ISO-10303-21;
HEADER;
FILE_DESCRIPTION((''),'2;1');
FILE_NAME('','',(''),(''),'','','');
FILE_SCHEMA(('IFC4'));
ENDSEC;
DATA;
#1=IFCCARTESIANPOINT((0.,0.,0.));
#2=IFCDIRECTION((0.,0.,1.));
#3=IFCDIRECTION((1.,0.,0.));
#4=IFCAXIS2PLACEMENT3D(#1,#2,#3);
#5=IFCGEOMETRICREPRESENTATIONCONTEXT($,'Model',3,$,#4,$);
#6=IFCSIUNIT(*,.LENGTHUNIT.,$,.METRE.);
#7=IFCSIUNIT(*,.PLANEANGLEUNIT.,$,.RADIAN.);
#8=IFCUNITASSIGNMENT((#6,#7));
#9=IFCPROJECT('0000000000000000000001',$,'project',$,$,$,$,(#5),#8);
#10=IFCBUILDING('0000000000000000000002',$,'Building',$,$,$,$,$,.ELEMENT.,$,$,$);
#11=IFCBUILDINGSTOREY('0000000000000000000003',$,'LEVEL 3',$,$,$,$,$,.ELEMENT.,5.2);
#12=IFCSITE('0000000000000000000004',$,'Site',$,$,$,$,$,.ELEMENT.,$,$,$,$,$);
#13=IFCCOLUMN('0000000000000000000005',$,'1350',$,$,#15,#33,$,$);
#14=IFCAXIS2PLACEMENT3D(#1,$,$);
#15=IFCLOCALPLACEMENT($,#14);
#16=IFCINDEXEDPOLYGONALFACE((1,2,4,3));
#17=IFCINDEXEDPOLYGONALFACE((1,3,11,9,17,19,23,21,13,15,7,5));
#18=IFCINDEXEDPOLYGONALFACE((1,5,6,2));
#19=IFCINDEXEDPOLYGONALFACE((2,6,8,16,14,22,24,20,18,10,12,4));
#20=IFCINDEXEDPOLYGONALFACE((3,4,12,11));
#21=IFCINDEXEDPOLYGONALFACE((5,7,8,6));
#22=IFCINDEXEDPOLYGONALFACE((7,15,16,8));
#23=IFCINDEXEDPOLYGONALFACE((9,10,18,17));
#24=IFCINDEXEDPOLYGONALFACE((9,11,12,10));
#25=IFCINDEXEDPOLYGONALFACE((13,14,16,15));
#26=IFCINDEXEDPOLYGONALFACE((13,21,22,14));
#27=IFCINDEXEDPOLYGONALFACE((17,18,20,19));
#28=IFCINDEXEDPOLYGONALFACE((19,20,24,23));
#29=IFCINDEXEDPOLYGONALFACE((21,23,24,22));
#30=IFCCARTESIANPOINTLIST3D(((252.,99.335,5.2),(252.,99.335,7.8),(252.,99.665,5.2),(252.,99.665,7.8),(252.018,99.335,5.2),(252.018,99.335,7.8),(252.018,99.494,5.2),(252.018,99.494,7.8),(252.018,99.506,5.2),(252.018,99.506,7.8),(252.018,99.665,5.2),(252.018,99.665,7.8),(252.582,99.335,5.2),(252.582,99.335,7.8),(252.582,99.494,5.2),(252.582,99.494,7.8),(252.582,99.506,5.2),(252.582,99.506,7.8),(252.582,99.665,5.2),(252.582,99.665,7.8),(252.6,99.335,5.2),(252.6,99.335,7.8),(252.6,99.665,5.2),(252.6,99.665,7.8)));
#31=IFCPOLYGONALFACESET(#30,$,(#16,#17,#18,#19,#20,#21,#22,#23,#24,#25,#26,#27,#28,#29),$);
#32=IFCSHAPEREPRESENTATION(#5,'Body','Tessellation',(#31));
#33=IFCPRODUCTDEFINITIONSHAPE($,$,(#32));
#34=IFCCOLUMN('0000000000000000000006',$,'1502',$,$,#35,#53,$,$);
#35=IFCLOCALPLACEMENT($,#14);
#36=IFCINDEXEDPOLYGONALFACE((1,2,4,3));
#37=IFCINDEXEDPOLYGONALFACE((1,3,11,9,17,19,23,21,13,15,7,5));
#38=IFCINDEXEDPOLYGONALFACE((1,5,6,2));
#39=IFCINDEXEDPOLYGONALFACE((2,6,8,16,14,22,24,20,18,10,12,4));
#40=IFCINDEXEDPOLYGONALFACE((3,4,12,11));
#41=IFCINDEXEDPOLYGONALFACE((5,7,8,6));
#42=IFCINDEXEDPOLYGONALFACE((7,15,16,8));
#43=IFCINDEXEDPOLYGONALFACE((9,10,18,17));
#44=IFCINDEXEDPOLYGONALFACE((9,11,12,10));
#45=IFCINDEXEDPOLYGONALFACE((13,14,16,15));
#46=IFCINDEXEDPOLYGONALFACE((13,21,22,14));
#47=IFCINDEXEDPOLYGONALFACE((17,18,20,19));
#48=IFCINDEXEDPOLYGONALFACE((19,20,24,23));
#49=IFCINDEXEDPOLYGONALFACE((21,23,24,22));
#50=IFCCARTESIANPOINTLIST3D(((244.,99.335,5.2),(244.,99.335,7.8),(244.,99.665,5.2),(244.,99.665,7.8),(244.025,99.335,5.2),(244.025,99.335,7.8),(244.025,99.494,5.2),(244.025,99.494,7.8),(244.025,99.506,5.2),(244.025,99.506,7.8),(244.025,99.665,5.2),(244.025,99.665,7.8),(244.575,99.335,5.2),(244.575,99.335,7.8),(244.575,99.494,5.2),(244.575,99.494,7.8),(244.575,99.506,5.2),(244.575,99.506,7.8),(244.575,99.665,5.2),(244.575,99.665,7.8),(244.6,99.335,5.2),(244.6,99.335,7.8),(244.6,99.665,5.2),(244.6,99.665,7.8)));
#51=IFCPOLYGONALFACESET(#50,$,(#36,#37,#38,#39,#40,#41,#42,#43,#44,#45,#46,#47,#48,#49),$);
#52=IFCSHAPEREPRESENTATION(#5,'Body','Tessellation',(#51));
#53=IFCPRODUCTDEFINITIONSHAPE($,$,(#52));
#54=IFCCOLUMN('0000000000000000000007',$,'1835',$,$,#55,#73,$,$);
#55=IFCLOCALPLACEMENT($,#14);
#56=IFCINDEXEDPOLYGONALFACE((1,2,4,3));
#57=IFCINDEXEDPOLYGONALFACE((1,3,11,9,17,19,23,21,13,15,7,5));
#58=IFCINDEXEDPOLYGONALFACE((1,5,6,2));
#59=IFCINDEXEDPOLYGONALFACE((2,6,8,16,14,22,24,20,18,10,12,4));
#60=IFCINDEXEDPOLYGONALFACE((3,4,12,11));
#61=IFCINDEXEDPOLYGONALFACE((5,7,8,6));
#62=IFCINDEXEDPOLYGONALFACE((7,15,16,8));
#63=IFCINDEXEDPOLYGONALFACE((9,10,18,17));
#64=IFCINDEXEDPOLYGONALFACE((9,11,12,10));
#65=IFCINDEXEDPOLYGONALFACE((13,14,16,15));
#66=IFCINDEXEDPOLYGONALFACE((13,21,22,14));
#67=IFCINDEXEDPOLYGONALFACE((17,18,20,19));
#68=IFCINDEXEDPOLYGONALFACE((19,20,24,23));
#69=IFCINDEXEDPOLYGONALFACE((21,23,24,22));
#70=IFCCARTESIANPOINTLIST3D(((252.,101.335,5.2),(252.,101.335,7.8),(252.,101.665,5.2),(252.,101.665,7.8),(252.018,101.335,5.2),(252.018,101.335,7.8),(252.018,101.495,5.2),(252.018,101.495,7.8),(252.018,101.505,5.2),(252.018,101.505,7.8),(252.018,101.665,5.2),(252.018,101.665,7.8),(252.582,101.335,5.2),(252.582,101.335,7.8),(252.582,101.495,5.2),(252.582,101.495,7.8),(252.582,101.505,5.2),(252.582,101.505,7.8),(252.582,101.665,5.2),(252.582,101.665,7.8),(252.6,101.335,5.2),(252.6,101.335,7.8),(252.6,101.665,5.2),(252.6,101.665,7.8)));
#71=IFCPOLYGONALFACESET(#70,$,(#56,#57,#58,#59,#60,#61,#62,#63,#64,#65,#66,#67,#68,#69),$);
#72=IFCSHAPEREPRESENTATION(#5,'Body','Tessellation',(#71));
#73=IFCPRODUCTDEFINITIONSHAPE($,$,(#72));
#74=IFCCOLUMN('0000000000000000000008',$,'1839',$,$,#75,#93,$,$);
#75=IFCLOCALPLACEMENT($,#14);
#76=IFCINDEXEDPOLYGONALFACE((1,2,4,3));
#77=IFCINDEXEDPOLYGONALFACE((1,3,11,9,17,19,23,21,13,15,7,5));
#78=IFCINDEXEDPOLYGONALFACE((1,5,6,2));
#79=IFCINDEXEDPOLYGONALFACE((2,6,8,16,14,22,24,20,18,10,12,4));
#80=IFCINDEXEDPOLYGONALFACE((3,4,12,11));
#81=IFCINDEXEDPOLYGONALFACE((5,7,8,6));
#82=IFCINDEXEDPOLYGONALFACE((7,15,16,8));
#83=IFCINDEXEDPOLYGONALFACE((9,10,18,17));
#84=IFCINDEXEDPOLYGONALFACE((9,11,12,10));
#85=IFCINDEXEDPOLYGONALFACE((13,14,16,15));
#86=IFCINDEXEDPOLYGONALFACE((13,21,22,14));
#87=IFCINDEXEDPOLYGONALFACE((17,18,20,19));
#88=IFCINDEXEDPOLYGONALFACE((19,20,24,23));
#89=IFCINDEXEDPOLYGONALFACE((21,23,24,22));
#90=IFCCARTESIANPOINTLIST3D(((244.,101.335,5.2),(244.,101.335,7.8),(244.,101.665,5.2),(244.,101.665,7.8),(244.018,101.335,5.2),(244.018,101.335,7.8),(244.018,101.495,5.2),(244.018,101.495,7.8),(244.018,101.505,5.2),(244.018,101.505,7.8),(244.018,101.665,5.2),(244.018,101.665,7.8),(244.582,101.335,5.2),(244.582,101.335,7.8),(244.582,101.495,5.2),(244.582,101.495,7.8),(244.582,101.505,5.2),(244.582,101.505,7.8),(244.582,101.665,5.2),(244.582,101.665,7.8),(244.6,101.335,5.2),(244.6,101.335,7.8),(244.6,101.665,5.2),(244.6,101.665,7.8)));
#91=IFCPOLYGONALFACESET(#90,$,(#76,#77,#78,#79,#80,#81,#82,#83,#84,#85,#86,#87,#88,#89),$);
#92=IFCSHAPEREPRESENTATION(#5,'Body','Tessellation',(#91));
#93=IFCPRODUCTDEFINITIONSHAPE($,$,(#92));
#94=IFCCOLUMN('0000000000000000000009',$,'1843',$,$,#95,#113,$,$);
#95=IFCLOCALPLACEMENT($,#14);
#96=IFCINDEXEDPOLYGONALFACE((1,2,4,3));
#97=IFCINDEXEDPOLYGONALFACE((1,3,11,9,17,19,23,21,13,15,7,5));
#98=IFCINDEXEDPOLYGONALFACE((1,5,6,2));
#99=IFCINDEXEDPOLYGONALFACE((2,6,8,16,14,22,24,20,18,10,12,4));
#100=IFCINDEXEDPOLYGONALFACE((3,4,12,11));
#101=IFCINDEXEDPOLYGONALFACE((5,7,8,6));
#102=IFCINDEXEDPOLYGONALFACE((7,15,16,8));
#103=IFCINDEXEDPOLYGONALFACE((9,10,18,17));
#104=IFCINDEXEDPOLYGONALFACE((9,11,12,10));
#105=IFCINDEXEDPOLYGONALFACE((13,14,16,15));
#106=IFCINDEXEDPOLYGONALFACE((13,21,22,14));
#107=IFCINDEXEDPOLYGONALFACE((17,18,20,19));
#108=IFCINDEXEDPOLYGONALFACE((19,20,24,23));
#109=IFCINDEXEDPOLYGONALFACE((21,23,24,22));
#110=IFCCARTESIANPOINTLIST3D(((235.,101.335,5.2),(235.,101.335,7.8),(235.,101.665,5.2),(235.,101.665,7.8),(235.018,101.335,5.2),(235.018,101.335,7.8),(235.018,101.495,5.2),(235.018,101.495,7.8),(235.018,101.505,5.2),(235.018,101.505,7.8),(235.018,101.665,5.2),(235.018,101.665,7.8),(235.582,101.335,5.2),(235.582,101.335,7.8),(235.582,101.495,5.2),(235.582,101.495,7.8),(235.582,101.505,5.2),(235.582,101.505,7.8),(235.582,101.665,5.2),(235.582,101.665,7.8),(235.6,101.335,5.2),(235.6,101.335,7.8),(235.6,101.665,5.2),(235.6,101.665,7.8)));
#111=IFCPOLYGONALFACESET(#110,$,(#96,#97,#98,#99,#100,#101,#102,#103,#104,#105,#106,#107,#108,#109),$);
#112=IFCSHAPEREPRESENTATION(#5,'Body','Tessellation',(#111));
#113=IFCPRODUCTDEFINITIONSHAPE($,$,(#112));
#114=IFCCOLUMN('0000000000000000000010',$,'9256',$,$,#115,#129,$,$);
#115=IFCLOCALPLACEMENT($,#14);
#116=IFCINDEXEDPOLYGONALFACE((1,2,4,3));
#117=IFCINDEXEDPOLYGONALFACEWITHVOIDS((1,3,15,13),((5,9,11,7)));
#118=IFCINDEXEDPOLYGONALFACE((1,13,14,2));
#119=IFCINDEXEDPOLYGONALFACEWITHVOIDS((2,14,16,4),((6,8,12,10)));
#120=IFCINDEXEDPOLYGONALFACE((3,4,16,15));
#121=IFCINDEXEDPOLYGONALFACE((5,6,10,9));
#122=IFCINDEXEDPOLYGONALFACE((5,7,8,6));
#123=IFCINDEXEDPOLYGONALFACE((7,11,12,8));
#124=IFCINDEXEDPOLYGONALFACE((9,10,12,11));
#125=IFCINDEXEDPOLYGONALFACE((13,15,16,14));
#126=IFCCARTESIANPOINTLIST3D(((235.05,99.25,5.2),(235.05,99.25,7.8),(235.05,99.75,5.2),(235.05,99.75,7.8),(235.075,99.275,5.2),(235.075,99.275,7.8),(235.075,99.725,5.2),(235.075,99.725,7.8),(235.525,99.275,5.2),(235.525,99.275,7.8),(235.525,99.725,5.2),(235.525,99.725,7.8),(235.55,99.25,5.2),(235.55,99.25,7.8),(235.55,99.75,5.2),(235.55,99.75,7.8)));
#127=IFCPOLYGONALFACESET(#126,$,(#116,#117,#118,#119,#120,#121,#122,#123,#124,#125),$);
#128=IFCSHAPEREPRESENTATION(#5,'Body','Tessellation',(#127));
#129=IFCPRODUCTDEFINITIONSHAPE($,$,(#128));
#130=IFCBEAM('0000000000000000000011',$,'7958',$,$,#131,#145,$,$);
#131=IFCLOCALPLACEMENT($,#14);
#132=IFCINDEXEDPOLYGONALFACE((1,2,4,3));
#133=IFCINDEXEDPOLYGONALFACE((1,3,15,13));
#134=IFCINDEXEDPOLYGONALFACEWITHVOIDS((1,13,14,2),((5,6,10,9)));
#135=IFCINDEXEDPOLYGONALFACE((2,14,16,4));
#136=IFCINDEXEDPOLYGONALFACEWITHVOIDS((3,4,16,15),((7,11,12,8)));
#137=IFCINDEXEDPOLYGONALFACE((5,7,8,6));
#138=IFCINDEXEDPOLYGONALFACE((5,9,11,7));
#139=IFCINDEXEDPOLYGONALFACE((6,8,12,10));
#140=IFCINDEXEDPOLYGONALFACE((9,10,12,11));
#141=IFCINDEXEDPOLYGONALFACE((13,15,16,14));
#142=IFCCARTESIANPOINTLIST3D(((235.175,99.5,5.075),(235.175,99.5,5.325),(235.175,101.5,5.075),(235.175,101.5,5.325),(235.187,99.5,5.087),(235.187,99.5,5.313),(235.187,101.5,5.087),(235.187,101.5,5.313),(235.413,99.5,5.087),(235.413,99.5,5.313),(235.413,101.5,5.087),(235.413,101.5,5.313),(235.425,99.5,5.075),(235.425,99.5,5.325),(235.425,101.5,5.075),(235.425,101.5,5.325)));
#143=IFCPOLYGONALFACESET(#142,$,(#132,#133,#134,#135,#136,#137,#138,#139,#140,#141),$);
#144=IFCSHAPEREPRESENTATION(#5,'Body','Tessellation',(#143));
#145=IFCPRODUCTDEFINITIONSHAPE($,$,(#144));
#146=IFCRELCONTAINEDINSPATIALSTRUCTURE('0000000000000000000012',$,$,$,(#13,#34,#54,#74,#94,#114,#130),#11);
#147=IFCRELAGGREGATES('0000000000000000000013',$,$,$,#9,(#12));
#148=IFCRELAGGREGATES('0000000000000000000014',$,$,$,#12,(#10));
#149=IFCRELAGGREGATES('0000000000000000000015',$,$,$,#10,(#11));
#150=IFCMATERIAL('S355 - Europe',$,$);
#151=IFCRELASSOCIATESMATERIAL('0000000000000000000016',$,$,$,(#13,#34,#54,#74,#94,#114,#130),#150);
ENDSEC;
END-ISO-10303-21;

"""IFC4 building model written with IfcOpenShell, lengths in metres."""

from ifc_helpers import new_model, si_unit, frame, origin_with_axes, origin_2d_with_axis, place, context, project, spatial, hollow_rectangle, i_section, extrude, material, material_profile, profile_set, profile_usage, element, save


model = new_model("IFC4")

# Units and contexts
model_context = context("Model", 3, world=origin_with_axes())
ifc_project = project(units=[si_unit("LENGTHUNIT", "METRE"), si_unit("PLANEANGLEUNIT", "RADIAN")], contexts=[model_context])

# Site, building, storey
site = spatial("IfcSite", under=ifc_project, Name="Site", CompositionType="ELEMENT")
building = spatial("IfcBuilding", under=site, Name="Building", CompositionType="ELEMENT")
storey = spatial("IfcBuildingStorey", under=building, Name="LEVEL 3", CompositionType="ELEMENT", Elevation=5.2)

# Columns
ifc_material = material(Name="S355 - Europe")
ifc_material_profile_1 = material_profile(ifc_material, i_section(OverallWidth=0.33, OverallDepth=0.6, WebThickness=0.012, FlangeThickness=0.018, at=origin_2d_with_axis()))
ifc_profile_set_1 = profile_set([ifc_material_profile_1])
ifc_profile_usage_1 = profile_usage(ifc_profile_set_1, cardinal=10)
column_1_placement = place(None, frame((252.3, 99.5, 5.2), z_axis=(0.0, 0.0, 1.0), x_axis=(0.0, -1.0, 0.0)))
element("IfcColumn", 1, at=column_1_placement, inside=storey, material=ifc_profile_usage_1, Name="1350", context=model_context, shape_type="SweptSolid", body=[
    extrude(i_section(OverallWidth=0.33, OverallDepth=0.6, WebThickness=0.012, FlangeThickness=0.018, at=origin_2d_with_axis()), origin_with_axes(), (0.0, 0.0, 1.0), 2.6),
])
ifc_material_profile_2 = material_profile(ifc_material, i_section(OverallWidth=0.33, OverallDepth=0.6, WebThickness=0.012, FlangeThickness=0.025, at=origin_2d_with_axis()))
ifc_profile_set_2 = profile_set([ifc_material_profile_2])
ifc_profile_usage_2 = profile_usage(ifc_profile_set_2, cardinal=10)
column_2_placement = place(None, frame((244.3, 99.5, 5.2), z_axis=(0.0, 0.0, 1.0), x_axis=(0.0, -1.0, 0.0)))
element("IfcColumn", 2, at=column_2_placement, inside=storey, material=ifc_profile_usage_2, Name="1502", context=model_context, shape_type="SweptSolid", body=[
    extrude(i_section(OverallWidth=0.33, OverallDepth=0.6, WebThickness=0.012, FlangeThickness=0.025, at=origin_2d_with_axis()), origin_with_axes(), (0.0, 0.0, 1.0), 2.6),
])
ifc_material_profile_3 = material_profile(ifc_material, i_section(OverallWidth=0.33, OverallDepth=0.6, WebThickness=0.01, FlangeThickness=0.018, at=origin_2d_with_axis()))
ifc_profile_set_3 = profile_set([ifc_material_profile_3])
ifc_profile_usage_3 = profile_usage(ifc_profile_set_3, cardinal=10)
column_3_placement = place(None, frame((252.3, 101.5, 5.2), z_axis=(0.0, 0.0, 1.0), x_axis=(0.0, -1.0, 0.0)))
element("IfcColumn", 3, at=column_3_placement, inside=storey, material=ifc_profile_usage_3, Name="1835", context=model_context, shape_type="SweptSolid", body=[
    extrude(i_section(OverallWidth=0.33, OverallDepth=0.6, WebThickness=0.01, FlangeThickness=0.018, at=origin_2d_with_axis()), origin_with_axes(), (0.0, 0.0, 1.0), 2.6),
])
ifc_material_profile_4 = material_profile(ifc_material, i_section(OverallWidth=0.33, OverallDepth=0.6, WebThickness=0.01, FlangeThickness=0.018, at=origin_2d_with_axis()))
ifc_profile_set_4 = profile_set([ifc_material_profile_4])
ifc_profile_usage_4 = profile_usage(ifc_profile_set_4, cardinal=10)
column_4_placement = place(None, frame((244.3, 101.5, 5.2), z_axis=(0.0, 0.0, 1.0), x_axis=(0.0, -1.0, 0.0)))
element("IfcColumn", 4, at=column_4_placement, inside=storey, material=ifc_profile_usage_4, Name="1839", context=model_context, shape_type="SweptSolid", body=[
    extrude(i_section(OverallWidth=0.33, OverallDepth=0.6, WebThickness=0.01, FlangeThickness=0.018, at=origin_2d_with_axis()), origin_with_axes(), (0.0, 0.0, 1.0), 2.6),
])
ifc_material_profile_5 = material_profile(ifc_material, i_section(OverallWidth=0.33, OverallDepth=0.6, WebThickness=0.01, FlangeThickness=0.018, at=origin_2d_with_axis()))
ifc_profile_set_5 = profile_set([ifc_material_profile_5])
ifc_profile_usage_5 = profile_usage(ifc_profile_set_5, cardinal=10)
column_5_placement = place(None, frame((235.3, 101.5, 5.2), z_axis=(0.0, 0.0, 1.0), x_axis=(0.0, -1.0, 0.0)))
element("IfcColumn", 5, at=column_5_placement, inside=storey, material=ifc_profile_usage_5, Name="1843", context=model_context, shape_type="SweptSolid", body=[
    extrude(i_section(OverallWidth=0.33, OverallDepth=0.6, WebThickness=0.01, FlangeThickness=0.018, at=origin_2d_with_axis()), origin_with_axes(), (0.0, 0.0, 1.0), 2.6),
])
ifc_material_profile_6 = material_profile(ifc_material, hollow_rectangle(XDim=0.5, YDim=0.5, WallThickness=0.025, at=origin_2d_with_axis()))
ifc_profile_set_6 = profile_set([ifc_material_profile_6])
ifc_profile_usage_6 = profile_usage(ifc_profile_set_6, cardinal=10)
column_6_placement = place(None, frame((235.3, 99.5, 5.2), z_axis=(0.0, 0.0, 1.0), x_axis=(0.0, -1.0, 0.0)))
element("IfcColumn", 6, at=column_6_placement, inside=storey, material=ifc_profile_usage_6, Name="9256", context=model_context, shape_type="SweptSolid", body=[
    extrude(hollow_rectangle(XDim=0.5, YDim=0.5, WallThickness=0.025, at=origin_2d_with_axis()), origin_with_axes(), (0.0, 0.0, 1.0), 2.6),
])

# Beam
ifc_material_profile_7 = material_profile(ifc_material, hollow_rectangle(XDim=0.25, YDim=0.25, WallThickness=0.012, at=origin_2d_with_axis()))
ifc_profile_set_7 = profile_set([ifc_material_profile_7])
ifc_profile_usage_7 = profile_usage(ifc_profile_set_7, cardinal=10)
beam_1_placement = place(None, frame((235.3, 101.5, 5.2), z_axis=(0.0, -1.0, 0.0), x_axis=(1.0, 0.0, 0.0)))
element("IfcBeam", 7, at=beam_1_placement, inside=storey, material=ifc_profile_usage_7, Name="7958", context=model_context, shape_type="SweptSolid", body=[
    extrude(hollow_rectangle(XDim=0.25, YDim=0.25, WallThickness=0.012, at=origin_2d_with_axis()), origin_with_axes(), (0.0, 0.0, 1.0), 2.0),
])

save(model, "model.ifc")
